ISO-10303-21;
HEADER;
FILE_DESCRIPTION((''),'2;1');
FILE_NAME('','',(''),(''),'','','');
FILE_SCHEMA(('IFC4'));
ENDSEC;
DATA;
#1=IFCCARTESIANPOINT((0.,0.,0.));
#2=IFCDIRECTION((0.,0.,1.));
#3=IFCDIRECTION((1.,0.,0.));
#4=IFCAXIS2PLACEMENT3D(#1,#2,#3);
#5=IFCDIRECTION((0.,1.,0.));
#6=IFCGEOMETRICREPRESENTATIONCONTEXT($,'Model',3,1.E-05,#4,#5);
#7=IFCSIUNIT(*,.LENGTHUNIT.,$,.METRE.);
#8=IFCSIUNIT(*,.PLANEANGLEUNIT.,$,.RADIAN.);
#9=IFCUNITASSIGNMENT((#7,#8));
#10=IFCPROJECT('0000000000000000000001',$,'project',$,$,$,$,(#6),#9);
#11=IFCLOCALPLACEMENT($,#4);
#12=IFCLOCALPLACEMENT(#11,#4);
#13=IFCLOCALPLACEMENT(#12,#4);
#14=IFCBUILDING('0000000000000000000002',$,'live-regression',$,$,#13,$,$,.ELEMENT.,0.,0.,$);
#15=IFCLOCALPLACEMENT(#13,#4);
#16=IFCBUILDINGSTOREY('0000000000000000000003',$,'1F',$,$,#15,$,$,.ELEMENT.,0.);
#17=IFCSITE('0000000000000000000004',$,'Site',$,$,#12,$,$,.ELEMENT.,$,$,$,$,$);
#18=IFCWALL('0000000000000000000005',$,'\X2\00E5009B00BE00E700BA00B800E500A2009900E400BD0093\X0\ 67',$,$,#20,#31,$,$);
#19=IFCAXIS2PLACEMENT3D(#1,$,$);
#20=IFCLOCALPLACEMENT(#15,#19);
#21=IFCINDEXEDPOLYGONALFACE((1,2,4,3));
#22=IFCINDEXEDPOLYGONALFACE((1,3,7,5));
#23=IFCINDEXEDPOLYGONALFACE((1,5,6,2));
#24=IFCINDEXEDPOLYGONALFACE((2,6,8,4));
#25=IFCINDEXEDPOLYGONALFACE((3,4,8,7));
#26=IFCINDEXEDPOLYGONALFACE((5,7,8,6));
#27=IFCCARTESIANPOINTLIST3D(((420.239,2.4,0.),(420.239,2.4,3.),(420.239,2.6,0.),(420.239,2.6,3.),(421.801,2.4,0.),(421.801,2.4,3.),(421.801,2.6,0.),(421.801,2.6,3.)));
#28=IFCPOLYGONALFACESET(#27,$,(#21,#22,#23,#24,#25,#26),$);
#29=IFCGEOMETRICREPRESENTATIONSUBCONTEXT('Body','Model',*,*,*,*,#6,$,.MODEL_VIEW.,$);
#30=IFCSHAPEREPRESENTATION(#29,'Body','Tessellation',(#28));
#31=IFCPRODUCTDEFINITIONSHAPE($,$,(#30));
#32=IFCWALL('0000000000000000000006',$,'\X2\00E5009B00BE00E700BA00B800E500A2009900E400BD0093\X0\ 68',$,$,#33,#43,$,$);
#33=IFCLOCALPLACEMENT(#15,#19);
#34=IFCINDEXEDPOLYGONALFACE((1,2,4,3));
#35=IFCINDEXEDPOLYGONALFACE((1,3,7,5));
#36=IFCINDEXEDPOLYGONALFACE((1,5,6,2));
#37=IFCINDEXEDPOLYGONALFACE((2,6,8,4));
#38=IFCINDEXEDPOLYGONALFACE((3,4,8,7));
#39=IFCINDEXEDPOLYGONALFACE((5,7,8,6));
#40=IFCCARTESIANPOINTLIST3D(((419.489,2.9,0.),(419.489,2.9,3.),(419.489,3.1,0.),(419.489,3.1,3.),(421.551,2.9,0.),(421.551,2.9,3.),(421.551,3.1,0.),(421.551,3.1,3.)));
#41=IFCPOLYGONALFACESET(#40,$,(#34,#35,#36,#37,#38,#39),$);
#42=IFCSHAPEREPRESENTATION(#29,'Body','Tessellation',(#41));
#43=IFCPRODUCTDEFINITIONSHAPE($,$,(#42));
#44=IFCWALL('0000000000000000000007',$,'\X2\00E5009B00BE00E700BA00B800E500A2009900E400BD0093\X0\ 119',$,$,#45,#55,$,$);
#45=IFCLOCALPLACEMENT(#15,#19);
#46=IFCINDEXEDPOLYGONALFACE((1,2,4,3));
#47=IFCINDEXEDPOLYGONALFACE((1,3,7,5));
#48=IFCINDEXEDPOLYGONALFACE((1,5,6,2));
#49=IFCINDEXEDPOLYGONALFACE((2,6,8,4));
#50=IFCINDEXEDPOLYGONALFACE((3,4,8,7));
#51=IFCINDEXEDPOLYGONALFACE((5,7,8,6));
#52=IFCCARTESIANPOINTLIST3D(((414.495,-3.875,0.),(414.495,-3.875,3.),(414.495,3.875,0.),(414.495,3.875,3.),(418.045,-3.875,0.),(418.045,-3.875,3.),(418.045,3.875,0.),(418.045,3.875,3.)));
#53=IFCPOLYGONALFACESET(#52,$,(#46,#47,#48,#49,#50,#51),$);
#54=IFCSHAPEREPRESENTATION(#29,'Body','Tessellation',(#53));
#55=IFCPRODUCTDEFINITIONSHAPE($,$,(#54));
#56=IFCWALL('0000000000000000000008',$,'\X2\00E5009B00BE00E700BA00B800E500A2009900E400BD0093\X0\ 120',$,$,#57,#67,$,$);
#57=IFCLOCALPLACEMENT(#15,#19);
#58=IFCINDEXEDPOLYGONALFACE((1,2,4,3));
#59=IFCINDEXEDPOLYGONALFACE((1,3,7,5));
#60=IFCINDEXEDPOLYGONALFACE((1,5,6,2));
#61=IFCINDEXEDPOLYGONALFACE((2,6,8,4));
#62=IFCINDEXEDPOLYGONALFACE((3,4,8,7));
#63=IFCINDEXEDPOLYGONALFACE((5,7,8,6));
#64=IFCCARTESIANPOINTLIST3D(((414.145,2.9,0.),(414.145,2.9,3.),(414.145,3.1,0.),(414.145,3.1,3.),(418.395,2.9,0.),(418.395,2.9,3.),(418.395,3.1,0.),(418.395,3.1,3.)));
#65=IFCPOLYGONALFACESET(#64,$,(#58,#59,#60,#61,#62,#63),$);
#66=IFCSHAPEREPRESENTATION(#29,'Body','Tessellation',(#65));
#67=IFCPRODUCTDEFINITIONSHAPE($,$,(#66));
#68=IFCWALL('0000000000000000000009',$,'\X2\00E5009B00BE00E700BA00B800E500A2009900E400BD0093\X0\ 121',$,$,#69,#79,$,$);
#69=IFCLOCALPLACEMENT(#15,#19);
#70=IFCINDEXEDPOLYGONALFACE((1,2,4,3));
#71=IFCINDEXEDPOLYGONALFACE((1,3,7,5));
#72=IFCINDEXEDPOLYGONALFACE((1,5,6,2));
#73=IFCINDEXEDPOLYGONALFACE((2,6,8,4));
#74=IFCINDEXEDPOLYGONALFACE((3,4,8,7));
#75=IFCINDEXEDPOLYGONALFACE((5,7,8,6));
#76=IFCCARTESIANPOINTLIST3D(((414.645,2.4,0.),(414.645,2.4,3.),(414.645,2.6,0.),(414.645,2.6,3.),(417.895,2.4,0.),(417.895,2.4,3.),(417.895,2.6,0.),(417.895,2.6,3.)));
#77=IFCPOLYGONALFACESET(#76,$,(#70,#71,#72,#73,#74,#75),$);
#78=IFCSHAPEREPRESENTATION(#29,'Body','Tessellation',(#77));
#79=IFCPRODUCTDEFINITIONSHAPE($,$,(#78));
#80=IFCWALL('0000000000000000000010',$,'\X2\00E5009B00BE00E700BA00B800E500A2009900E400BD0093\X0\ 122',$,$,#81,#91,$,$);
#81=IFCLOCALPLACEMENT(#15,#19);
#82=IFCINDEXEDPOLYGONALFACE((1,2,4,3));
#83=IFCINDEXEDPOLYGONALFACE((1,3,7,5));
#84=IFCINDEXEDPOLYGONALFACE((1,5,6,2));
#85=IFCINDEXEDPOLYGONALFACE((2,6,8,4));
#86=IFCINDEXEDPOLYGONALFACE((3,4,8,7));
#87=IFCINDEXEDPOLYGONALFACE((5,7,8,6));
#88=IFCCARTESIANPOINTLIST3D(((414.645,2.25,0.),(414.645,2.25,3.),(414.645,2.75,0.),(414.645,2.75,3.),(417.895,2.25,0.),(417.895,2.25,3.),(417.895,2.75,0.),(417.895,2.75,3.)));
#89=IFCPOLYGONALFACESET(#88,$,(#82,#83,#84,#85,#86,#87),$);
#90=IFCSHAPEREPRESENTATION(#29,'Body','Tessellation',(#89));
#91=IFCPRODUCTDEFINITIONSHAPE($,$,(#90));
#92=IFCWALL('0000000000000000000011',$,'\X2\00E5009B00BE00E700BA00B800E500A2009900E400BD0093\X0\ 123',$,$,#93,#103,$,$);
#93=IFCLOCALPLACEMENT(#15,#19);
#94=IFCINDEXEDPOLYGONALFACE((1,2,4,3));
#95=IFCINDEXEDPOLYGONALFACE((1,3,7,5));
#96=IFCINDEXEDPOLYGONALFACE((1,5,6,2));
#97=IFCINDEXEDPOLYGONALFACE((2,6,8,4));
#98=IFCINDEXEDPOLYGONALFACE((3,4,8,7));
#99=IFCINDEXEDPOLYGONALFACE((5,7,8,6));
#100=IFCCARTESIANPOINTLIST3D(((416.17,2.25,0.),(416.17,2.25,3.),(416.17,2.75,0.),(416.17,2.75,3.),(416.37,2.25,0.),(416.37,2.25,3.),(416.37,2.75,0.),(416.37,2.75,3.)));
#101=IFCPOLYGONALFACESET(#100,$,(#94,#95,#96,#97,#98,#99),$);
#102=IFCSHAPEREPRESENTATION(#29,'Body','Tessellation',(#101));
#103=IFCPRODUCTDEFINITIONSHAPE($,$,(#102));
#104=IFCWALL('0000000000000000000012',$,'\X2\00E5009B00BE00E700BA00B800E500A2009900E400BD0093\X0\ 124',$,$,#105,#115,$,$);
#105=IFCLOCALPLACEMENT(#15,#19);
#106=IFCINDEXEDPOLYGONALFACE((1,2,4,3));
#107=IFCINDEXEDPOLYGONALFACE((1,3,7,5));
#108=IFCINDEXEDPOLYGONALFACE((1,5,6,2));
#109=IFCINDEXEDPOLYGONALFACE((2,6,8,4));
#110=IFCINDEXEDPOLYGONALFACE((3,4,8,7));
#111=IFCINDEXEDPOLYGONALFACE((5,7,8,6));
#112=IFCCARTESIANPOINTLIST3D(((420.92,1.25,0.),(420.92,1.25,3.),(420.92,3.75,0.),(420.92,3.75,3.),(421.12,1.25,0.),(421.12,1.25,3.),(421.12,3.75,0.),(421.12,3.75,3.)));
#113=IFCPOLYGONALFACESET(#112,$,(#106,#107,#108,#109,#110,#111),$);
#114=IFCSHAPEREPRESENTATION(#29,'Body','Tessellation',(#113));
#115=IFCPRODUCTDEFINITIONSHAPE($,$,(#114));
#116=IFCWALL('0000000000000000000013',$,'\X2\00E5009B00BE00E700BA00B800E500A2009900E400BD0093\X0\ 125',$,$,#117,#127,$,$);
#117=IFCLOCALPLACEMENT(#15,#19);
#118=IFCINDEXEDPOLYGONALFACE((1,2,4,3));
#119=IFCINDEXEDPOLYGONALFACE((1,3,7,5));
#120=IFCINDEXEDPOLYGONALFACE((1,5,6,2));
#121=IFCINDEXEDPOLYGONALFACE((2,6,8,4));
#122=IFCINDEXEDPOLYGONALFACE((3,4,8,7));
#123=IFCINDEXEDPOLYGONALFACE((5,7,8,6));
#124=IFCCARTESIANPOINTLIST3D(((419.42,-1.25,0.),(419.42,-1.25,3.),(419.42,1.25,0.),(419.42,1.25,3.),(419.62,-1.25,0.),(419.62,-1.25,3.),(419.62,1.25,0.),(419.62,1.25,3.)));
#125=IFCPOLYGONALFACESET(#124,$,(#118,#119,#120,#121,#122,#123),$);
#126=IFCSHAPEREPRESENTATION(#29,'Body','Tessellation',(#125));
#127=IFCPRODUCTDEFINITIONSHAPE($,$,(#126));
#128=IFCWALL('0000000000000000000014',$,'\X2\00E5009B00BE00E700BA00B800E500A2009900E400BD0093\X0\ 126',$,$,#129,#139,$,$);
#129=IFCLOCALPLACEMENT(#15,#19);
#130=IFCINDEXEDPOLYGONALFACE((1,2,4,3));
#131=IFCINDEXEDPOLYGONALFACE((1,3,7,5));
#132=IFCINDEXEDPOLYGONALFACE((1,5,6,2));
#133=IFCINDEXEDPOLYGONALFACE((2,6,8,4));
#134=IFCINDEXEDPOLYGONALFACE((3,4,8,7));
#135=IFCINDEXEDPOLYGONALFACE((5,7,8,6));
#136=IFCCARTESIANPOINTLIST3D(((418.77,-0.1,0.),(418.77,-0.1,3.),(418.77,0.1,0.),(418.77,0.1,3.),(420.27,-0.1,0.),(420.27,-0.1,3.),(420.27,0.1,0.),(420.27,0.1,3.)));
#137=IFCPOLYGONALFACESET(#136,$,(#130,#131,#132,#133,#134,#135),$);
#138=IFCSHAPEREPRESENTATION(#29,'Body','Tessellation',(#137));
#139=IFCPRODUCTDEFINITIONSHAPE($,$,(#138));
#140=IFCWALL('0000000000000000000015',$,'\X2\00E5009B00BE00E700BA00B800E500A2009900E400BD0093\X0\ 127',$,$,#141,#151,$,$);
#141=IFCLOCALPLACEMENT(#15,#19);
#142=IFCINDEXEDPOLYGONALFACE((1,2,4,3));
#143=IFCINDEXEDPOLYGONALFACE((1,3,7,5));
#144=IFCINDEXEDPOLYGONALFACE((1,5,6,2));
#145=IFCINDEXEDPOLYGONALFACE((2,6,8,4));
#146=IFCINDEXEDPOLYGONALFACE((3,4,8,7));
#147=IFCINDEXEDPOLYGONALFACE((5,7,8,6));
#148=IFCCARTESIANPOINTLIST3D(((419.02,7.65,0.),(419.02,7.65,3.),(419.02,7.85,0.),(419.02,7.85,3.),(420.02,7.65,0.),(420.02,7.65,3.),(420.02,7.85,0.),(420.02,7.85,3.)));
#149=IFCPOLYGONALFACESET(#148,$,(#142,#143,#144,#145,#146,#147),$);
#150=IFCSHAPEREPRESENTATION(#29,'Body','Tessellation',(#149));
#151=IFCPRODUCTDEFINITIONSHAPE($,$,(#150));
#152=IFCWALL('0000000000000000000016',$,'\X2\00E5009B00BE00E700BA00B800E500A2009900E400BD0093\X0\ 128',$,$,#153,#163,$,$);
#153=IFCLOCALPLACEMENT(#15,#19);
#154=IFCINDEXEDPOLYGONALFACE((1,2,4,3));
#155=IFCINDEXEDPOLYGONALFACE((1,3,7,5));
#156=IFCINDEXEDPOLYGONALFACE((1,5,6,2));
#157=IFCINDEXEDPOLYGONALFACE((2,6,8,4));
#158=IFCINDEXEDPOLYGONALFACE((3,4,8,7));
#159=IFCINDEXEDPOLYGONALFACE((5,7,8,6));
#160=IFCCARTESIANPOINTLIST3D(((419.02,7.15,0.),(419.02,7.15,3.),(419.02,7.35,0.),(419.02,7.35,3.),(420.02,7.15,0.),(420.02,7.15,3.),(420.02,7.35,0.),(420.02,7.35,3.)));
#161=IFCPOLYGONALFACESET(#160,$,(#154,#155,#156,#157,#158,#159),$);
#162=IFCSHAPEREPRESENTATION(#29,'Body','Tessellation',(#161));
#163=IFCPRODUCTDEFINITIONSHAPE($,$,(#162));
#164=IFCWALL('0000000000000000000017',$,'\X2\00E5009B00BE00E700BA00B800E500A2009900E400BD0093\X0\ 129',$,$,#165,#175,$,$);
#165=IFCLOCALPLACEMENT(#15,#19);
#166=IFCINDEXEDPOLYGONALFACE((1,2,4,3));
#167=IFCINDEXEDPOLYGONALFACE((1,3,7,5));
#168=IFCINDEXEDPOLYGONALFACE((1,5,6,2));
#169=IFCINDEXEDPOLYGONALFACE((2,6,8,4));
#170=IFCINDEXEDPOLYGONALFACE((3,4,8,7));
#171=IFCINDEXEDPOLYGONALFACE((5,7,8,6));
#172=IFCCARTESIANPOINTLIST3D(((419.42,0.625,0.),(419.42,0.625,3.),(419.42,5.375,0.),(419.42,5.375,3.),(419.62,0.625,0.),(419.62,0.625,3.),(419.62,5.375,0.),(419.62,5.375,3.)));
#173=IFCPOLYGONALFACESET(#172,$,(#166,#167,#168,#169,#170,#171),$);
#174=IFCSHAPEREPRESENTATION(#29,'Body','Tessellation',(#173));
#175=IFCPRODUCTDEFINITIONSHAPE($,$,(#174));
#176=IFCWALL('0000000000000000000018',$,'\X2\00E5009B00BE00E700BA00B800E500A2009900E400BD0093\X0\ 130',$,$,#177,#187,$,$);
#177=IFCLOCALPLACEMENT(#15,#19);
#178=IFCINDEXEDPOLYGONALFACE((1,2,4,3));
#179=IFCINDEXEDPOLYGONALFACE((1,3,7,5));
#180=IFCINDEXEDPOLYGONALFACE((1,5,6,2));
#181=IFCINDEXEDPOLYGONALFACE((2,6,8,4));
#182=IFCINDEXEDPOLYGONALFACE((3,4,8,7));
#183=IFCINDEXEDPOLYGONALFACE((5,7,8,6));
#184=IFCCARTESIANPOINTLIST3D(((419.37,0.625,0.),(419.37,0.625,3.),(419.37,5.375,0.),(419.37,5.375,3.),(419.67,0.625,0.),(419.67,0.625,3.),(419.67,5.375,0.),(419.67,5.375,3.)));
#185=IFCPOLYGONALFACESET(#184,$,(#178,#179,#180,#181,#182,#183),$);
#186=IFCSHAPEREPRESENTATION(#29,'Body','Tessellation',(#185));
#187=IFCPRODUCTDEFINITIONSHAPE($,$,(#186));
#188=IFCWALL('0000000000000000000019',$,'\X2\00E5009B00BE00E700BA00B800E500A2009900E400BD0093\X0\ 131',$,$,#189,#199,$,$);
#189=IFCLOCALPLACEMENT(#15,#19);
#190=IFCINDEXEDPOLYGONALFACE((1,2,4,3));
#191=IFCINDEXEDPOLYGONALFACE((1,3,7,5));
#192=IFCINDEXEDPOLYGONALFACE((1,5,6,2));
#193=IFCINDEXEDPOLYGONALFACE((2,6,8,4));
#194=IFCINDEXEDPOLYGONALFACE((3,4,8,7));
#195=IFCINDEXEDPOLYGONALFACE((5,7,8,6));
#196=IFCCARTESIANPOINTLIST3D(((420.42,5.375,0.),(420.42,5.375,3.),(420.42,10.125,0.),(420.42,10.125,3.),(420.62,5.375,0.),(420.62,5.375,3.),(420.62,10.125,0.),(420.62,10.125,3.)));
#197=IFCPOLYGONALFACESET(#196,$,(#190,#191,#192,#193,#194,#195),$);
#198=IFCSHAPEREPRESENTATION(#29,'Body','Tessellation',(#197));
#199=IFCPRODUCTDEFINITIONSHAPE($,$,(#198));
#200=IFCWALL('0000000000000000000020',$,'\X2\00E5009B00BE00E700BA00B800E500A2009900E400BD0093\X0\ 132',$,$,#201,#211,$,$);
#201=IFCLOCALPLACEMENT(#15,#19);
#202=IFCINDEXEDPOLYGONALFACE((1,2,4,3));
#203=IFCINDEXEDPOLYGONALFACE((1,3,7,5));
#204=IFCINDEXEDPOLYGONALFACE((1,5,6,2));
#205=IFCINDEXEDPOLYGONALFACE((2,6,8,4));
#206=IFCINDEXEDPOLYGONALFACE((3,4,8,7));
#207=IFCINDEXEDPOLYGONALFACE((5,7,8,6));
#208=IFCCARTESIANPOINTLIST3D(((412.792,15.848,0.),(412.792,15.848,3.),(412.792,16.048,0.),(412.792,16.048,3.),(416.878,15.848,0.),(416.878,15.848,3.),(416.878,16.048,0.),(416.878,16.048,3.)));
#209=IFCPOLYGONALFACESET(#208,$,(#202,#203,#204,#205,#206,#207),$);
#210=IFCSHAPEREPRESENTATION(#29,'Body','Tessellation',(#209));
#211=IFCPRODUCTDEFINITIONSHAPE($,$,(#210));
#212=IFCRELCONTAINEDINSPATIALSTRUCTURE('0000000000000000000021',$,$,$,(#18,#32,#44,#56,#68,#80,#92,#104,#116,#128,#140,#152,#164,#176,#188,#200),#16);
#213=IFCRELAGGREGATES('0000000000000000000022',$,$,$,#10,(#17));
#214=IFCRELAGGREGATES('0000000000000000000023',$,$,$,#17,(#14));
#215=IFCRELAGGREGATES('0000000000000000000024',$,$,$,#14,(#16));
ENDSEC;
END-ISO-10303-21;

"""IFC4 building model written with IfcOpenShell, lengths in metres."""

from ifc_helpers import new_model, si_unit, direction, frame, frame_2d, origin_with_axes, place, context, subcontext, project, spatial, rectangle, extrude, element, save


model = new_model("IFC4")

# Units and contexts
model_context = context("Model", 3, precision=1e-05, world=origin_with_axes(), true_north=direction((0.0, 1.0, 0.0)))
body_context = subcontext(model_context, "Body", "Model", "MODEL_VIEW")
ifc_project = project(units=[si_unit("LENGTHUNIT", "METRE"), si_unit("PLANEANGLEUNIT", "RADIAN")], contexts=[model_context])

# Site, building, storey
placement = place(None, origin_with_axes())
site_placement = place(placement, origin_with_axes())
site = spatial("IfcSite", under=ifc_project, at=site_placement, Name="Site", CompositionType="ELEMENT")
building_placement = place(site_placement, origin_with_axes())
building = spatial("IfcBuilding", under=site, at=building_placement, Name="live-regression", CompositionType="ELEMENT", ElevationOfRefHeight=0.0, ElevationOfTerrain=0.0)
storey_placement = place(building_placement, origin_with_axes())
storey = spatial("IfcBuildingStorey", under=building, at=storey_placement, Name="1F", CompositionType="ELEMENT", Elevation=0.0)

# Walls
wall_1_placement = place(storey_placement, frame((421.02, 2.5, 0.0), z_axis=(0.0, 0.0, 1.0), x_axis=(1.0, 0.0, 0.0)))
element("IfcWall", 1, at=wall_1_placement, inside=storey, Name="å\u009b¾çº¸å¢\u0099ä½\u0093 67", context=body_context, shape_type="SweptSolid", body=[
    extrude(rectangle(XDim=1.562, YDim=0.2, at=frame_2d((0.0, 0.0), x_axis=(1.0, 0.0, 0.0))), frame((0.0, 0.0, 0.0), z_axis=(0.0, 0.0, 1.0)), (0.0, 0.0, 1.0), 3.0),
])
wall_2_placement = place(storey_placement, frame((420.52, 3.0, 0.0), z_axis=(0.0, 0.0, 1.0), x_axis=(1.0, 0.0, 0.0)))
element("IfcWall", 2, at=wall_2_placement, inside=storey, Name="å\u009b¾çº¸å¢\u0099ä½\u0093 68", context=body_context, shape_type="SweptSolid", body=[
    extrude(rectangle(XDim=2.062, YDim=0.2, at=frame_2d((0.0, 0.0), x_axis=(1.0, 0.0, 0.0))), frame((0.0, 0.0, 0.0), z_axis=(0.0, 0.0, 1.0)), (0.0, 0.0, 1.0), 3.0),
])
wall_3_placement = place(storey_placement, frame((416.27, 0.0, 0.0), z_axis=(0.0, 0.0, 1.0), x_axis=(1.0, 0.0, 0.0)))
element("IfcWall", 3, at=wall_3_placement, inside=storey, Name="å\u009b¾çº¸å¢\u0099ä½\u0093 119", context=body_context, shape_type="SweptSolid", body=[
    extrude(rectangle(XDim=3.55, YDim=7.75, at=frame_2d((0.0, 0.0), x_axis=(1.0, 0.0, 0.0))), frame((0.0, 0.0, 0.0), z_axis=(0.0, 0.0, 1.0)), (0.0, 0.0, 1.0), 3.0),
])
wall_4_placement = place(storey_placement, frame((416.27, 3.0, 0.0), z_axis=(0.0, 0.0, 1.0), x_axis=(1.0, 0.0, 0.0)))
element("IfcWall", 4, at=wall_4_placement, inside=storey, Name="å\u009b¾çº¸å¢\u0099ä½\u0093 120", context=body_context, shape_type="SweptSolid", body=[
    extrude(rectangle(XDim=4.25, YDim=0.2, at=frame_2d((0.0, 0.0), x_axis=(1.0, 0.0, 0.0))), frame((0.0, 0.0, 0.0), z_axis=(0.0, 0.0, 1.0)), (0.0, 0.0, 1.0), 3.0),
])
wall_5_placement = place(storey_placement, frame((416.27, 2.5, 0.0), z_axis=(0.0, 0.0, 1.0), x_axis=(1.0, 0.0, 0.0)))
element("IfcWall", 5, at=wall_5_placement, inside=storey, Name="å\u009b¾çº¸å¢\u0099ä½\u0093 121", context=body_context, shape_type="SweptSolid", body=[
    extrude(rectangle(XDim=3.25, YDim=0.2, at=frame_2d((0.0, 0.0), x_axis=(1.0, 0.0, 0.0))), frame((0.0, 0.0, 0.0), z_axis=(0.0, 0.0, 1.0)), (0.0, 0.0, 1.0), 3.0),
])
wall_6_placement = place(storey_placement, frame((416.27, 2.5, 0.0), z_axis=(0.0, 0.0, 1.0), x_axis=(1.0, 0.0, 0.0)))
element("IfcWall", 6, at=wall_6_placement, inside=storey, Name="å\u009b¾çº¸å¢\u0099ä½\u0093 122", context=body_context, shape_type="SweptSolid", body=[
    extrude(rectangle(XDim=3.25, YDim=0.5, at=frame_2d((0.0, 0.0), x_axis=(1.0, 0.0, 0.0))), frame((0.0, 0.0, 0.0), z_axis=(0.0, 0.0, 1.0)), (0.0, 0.0, 1.0), 3.0),
])
wall_7_placement = place(storey_placement, frame((416.27, 2.5, 0.0), z_axis=(0.0, 0.0, 1.0), x_axis=(0.0, 1.0, 0.0)))
element("IfcWall", 7, at=wall_7_placement, inside=storey, Name="å\u009b¾çº¸å¢\u0099ä½\u0093 123", context=body_context, shape_type="SweptSolid", body=[
    extrude(rectangle(XDim=0.5, YDim=0.2, at=frame_2d((0.0, 0.0), x_axis=(1.0, 0.0, 0.0))), frame((0.0, 0.0, 0.0), z_axis=(0.0, 0.0, 1.0)), (0.0, 0.0, 1.0), 3.0),
])
for number, where, z_axis, x_axis, name in (
    (8, (421.02, 2.5, 0.0), (0.0, 0.0, 1.0), (0.0, -1.0, 0.0), "å\u009b¾çº¸å¢\u0099ä½\u0093 124"),
    (9, (419.52, 0.0, 0.0), (0.0, 0.0, 1.0), (0.0, 1.0, 0.0), "å\u009b¾çº¸å¢\u0099ä½\u0093 125"),
):
    element("IfcWall", number, at=place(storey_placement, frame(where, z_axis=z_axis, x_axis=x_axis)), inside=storey, Name=name, context=body_context, shape_type="SweptSolid", body=[
        extrude(rectangle(XDim=2.5, YDim=0.2, at=frame_2d((0.0, 0.0), x_axis=(1.0, 0.0, 0.0))), frame((0.0, 0.0, 0.0), z_axis=(0.0, 0.0, 1.0)), (0.0, 0.0, 1.0), 3.0),
    ])
wall_8_placement = place(storey_placement, frame((419.52, 0.0, 0.0), z_axis=(0.0, 0.0, 1.0), x_axis=(1.0, 0.0, 0.0)))
element("IfcWall", 10, at=wall_8_placement, inside=storey, Name="å\u009b¾çº¸å¢\u0099ä½\u0093 126", context=body_context, shape_type="SweptSolid", body=[
    extrude(rectangle(XDim=1.5, YDim=0.2, at=frame_2d((0.0, 0.0), x_axis=(1.0, 0.0, 0.0))), frame((0.0, 0.0, 0.0), z_axis=(0.0, 0.0, 1.0)), (0.0, 0.0, 1.0), 3.0),
])
for number, where, z_axis, x_axis, name in (
    (11, (419.52, 7.75, 0.0), (0.0, 0.0, 1.0), (1.0, 0.0, 0.0), "å\u009b¾çº¸å¢\u0099ä½\u0093 127"),
    (12, (419.52, 7.25, 0.0), (0.0, 0.0, 1.0), (1.0, 0.0, 0.0), "å\u009b¾çº¸å¢\u0099ä½\u0093 128"),
):
    element("IfcWall", number, at=place(storey_placement, frame(where, z_axis=z_axis, x_axis=x_axis)), inside=storey, Name=name, context=body_context, shape_type="SweptSolid", body=[
        extrude(rectangle(XDim=1.0, YDim=0.2, at=frame_2d((0.0, 0.0), x_axis=(1.0, 0.0, 0.0))), frame((0.0, 0.0, 0.0), z_axis=(0.0, 0.0, 1.0)), (0.0, 0.0, 1.0), 3.0),
    ])
wall_9_placement = place(storey_placement, frame((419.52, 3.0, 0.0), z_axis=(0.0, 0.0, 1.0), x_axis=(0.0, 1.0, 0.0)))
element("IfcWall", 13, at=wall_9_placement, inside=storey, Name="å\u009b¾çº¸å¢\u0099ä½\u0093 129", context=body_context, shape_type="SweptSolid", body=[
    extrude(rectangle(XDim=4.75, YDim=0.2, at=frame_2d((0.0, 0.0), x_axis=(1.0, 0.0, 0.0))), frame((0.0, 0.0, 0.0), z_axis=(0.0, 0.0, 1.0)), (0.0, 0.0, 1.0), 3.0),
])
wall_10_placement = place(storey_placement, frame((419.52, 3.0, 0.0), z_axis=(0.0, 0.0, 1.0), x_axis=(1.0, 0.0, 0.0)))
element("IfcWall", 14, at=wall_10_placement, inside=storey, Name="å\u009b¾çº¸å¢\u0099ä½\u0093 130", context=body_context, shape_type="SweptSolid", body=[
    extrude(rectangle(XDim=0.3, YDim=4.75, at=frame_2d((0.0, 0.0), x_axis=(1.0, 0.0, 0.0))), frame((0.0, 0.0, 0.0), z_axis=(0.0, 0.0, 1.0)), (0.0, 0.0, 1.0), 3.0),
])
wall_11_placement = place(storey_placement, frame((420.52, 7.75, 0.0), z_axis=(0.0, 0.0, 1.0), x_axis=(0.0, -1.0, 0.0)))
element("IfcWall", 15, at=wall_11_placement, inside=storey, Name="å\u009b¾çº¸å¢\u0099ä½\u0093 131", context=body_context, shape_type="SweptSolid", body=[
    extrude(rectangle(XDim=4.75, YDim=0.2, at=frame_2d((0.0, 0.0), x_axis=(1.0, 0.0, 0.0))), frame((0.0, 0.0, 0.0), z_axis=(0.0, 0.0, 1.0)), (0.0, 0.0, 1.0), 3.0),
])
for number, where, z_axis, x_axis, name in (
    (16, (414.835, 15.948, 0.0), (0.0, 0.0, 1.0), (1.0, 0.0, 0.0), "å\u009b¾çº¸å¢\u0099ä½\u0093 132"),
):
    element("IfcWall", number, at=place(storey_placement, frame(where, z_axis=z_axis, x_axis=x_axis)), inside=storey, Name=name, context=body_context, shape_type="SweptSolid", body=[
        extrude(rectangle(XDim=4.086, YDim=0.2, at=frame_2d((0.0, 0.0), x_axis=(1.0, 0.0, 0.0))), frame((0.0, 0.0, 0.0), z_axis=(0.0, 0.0, 1.0)), (0.0, 0.0, 1.0), 3.0),
    ])

save(model, "model.ifc")
